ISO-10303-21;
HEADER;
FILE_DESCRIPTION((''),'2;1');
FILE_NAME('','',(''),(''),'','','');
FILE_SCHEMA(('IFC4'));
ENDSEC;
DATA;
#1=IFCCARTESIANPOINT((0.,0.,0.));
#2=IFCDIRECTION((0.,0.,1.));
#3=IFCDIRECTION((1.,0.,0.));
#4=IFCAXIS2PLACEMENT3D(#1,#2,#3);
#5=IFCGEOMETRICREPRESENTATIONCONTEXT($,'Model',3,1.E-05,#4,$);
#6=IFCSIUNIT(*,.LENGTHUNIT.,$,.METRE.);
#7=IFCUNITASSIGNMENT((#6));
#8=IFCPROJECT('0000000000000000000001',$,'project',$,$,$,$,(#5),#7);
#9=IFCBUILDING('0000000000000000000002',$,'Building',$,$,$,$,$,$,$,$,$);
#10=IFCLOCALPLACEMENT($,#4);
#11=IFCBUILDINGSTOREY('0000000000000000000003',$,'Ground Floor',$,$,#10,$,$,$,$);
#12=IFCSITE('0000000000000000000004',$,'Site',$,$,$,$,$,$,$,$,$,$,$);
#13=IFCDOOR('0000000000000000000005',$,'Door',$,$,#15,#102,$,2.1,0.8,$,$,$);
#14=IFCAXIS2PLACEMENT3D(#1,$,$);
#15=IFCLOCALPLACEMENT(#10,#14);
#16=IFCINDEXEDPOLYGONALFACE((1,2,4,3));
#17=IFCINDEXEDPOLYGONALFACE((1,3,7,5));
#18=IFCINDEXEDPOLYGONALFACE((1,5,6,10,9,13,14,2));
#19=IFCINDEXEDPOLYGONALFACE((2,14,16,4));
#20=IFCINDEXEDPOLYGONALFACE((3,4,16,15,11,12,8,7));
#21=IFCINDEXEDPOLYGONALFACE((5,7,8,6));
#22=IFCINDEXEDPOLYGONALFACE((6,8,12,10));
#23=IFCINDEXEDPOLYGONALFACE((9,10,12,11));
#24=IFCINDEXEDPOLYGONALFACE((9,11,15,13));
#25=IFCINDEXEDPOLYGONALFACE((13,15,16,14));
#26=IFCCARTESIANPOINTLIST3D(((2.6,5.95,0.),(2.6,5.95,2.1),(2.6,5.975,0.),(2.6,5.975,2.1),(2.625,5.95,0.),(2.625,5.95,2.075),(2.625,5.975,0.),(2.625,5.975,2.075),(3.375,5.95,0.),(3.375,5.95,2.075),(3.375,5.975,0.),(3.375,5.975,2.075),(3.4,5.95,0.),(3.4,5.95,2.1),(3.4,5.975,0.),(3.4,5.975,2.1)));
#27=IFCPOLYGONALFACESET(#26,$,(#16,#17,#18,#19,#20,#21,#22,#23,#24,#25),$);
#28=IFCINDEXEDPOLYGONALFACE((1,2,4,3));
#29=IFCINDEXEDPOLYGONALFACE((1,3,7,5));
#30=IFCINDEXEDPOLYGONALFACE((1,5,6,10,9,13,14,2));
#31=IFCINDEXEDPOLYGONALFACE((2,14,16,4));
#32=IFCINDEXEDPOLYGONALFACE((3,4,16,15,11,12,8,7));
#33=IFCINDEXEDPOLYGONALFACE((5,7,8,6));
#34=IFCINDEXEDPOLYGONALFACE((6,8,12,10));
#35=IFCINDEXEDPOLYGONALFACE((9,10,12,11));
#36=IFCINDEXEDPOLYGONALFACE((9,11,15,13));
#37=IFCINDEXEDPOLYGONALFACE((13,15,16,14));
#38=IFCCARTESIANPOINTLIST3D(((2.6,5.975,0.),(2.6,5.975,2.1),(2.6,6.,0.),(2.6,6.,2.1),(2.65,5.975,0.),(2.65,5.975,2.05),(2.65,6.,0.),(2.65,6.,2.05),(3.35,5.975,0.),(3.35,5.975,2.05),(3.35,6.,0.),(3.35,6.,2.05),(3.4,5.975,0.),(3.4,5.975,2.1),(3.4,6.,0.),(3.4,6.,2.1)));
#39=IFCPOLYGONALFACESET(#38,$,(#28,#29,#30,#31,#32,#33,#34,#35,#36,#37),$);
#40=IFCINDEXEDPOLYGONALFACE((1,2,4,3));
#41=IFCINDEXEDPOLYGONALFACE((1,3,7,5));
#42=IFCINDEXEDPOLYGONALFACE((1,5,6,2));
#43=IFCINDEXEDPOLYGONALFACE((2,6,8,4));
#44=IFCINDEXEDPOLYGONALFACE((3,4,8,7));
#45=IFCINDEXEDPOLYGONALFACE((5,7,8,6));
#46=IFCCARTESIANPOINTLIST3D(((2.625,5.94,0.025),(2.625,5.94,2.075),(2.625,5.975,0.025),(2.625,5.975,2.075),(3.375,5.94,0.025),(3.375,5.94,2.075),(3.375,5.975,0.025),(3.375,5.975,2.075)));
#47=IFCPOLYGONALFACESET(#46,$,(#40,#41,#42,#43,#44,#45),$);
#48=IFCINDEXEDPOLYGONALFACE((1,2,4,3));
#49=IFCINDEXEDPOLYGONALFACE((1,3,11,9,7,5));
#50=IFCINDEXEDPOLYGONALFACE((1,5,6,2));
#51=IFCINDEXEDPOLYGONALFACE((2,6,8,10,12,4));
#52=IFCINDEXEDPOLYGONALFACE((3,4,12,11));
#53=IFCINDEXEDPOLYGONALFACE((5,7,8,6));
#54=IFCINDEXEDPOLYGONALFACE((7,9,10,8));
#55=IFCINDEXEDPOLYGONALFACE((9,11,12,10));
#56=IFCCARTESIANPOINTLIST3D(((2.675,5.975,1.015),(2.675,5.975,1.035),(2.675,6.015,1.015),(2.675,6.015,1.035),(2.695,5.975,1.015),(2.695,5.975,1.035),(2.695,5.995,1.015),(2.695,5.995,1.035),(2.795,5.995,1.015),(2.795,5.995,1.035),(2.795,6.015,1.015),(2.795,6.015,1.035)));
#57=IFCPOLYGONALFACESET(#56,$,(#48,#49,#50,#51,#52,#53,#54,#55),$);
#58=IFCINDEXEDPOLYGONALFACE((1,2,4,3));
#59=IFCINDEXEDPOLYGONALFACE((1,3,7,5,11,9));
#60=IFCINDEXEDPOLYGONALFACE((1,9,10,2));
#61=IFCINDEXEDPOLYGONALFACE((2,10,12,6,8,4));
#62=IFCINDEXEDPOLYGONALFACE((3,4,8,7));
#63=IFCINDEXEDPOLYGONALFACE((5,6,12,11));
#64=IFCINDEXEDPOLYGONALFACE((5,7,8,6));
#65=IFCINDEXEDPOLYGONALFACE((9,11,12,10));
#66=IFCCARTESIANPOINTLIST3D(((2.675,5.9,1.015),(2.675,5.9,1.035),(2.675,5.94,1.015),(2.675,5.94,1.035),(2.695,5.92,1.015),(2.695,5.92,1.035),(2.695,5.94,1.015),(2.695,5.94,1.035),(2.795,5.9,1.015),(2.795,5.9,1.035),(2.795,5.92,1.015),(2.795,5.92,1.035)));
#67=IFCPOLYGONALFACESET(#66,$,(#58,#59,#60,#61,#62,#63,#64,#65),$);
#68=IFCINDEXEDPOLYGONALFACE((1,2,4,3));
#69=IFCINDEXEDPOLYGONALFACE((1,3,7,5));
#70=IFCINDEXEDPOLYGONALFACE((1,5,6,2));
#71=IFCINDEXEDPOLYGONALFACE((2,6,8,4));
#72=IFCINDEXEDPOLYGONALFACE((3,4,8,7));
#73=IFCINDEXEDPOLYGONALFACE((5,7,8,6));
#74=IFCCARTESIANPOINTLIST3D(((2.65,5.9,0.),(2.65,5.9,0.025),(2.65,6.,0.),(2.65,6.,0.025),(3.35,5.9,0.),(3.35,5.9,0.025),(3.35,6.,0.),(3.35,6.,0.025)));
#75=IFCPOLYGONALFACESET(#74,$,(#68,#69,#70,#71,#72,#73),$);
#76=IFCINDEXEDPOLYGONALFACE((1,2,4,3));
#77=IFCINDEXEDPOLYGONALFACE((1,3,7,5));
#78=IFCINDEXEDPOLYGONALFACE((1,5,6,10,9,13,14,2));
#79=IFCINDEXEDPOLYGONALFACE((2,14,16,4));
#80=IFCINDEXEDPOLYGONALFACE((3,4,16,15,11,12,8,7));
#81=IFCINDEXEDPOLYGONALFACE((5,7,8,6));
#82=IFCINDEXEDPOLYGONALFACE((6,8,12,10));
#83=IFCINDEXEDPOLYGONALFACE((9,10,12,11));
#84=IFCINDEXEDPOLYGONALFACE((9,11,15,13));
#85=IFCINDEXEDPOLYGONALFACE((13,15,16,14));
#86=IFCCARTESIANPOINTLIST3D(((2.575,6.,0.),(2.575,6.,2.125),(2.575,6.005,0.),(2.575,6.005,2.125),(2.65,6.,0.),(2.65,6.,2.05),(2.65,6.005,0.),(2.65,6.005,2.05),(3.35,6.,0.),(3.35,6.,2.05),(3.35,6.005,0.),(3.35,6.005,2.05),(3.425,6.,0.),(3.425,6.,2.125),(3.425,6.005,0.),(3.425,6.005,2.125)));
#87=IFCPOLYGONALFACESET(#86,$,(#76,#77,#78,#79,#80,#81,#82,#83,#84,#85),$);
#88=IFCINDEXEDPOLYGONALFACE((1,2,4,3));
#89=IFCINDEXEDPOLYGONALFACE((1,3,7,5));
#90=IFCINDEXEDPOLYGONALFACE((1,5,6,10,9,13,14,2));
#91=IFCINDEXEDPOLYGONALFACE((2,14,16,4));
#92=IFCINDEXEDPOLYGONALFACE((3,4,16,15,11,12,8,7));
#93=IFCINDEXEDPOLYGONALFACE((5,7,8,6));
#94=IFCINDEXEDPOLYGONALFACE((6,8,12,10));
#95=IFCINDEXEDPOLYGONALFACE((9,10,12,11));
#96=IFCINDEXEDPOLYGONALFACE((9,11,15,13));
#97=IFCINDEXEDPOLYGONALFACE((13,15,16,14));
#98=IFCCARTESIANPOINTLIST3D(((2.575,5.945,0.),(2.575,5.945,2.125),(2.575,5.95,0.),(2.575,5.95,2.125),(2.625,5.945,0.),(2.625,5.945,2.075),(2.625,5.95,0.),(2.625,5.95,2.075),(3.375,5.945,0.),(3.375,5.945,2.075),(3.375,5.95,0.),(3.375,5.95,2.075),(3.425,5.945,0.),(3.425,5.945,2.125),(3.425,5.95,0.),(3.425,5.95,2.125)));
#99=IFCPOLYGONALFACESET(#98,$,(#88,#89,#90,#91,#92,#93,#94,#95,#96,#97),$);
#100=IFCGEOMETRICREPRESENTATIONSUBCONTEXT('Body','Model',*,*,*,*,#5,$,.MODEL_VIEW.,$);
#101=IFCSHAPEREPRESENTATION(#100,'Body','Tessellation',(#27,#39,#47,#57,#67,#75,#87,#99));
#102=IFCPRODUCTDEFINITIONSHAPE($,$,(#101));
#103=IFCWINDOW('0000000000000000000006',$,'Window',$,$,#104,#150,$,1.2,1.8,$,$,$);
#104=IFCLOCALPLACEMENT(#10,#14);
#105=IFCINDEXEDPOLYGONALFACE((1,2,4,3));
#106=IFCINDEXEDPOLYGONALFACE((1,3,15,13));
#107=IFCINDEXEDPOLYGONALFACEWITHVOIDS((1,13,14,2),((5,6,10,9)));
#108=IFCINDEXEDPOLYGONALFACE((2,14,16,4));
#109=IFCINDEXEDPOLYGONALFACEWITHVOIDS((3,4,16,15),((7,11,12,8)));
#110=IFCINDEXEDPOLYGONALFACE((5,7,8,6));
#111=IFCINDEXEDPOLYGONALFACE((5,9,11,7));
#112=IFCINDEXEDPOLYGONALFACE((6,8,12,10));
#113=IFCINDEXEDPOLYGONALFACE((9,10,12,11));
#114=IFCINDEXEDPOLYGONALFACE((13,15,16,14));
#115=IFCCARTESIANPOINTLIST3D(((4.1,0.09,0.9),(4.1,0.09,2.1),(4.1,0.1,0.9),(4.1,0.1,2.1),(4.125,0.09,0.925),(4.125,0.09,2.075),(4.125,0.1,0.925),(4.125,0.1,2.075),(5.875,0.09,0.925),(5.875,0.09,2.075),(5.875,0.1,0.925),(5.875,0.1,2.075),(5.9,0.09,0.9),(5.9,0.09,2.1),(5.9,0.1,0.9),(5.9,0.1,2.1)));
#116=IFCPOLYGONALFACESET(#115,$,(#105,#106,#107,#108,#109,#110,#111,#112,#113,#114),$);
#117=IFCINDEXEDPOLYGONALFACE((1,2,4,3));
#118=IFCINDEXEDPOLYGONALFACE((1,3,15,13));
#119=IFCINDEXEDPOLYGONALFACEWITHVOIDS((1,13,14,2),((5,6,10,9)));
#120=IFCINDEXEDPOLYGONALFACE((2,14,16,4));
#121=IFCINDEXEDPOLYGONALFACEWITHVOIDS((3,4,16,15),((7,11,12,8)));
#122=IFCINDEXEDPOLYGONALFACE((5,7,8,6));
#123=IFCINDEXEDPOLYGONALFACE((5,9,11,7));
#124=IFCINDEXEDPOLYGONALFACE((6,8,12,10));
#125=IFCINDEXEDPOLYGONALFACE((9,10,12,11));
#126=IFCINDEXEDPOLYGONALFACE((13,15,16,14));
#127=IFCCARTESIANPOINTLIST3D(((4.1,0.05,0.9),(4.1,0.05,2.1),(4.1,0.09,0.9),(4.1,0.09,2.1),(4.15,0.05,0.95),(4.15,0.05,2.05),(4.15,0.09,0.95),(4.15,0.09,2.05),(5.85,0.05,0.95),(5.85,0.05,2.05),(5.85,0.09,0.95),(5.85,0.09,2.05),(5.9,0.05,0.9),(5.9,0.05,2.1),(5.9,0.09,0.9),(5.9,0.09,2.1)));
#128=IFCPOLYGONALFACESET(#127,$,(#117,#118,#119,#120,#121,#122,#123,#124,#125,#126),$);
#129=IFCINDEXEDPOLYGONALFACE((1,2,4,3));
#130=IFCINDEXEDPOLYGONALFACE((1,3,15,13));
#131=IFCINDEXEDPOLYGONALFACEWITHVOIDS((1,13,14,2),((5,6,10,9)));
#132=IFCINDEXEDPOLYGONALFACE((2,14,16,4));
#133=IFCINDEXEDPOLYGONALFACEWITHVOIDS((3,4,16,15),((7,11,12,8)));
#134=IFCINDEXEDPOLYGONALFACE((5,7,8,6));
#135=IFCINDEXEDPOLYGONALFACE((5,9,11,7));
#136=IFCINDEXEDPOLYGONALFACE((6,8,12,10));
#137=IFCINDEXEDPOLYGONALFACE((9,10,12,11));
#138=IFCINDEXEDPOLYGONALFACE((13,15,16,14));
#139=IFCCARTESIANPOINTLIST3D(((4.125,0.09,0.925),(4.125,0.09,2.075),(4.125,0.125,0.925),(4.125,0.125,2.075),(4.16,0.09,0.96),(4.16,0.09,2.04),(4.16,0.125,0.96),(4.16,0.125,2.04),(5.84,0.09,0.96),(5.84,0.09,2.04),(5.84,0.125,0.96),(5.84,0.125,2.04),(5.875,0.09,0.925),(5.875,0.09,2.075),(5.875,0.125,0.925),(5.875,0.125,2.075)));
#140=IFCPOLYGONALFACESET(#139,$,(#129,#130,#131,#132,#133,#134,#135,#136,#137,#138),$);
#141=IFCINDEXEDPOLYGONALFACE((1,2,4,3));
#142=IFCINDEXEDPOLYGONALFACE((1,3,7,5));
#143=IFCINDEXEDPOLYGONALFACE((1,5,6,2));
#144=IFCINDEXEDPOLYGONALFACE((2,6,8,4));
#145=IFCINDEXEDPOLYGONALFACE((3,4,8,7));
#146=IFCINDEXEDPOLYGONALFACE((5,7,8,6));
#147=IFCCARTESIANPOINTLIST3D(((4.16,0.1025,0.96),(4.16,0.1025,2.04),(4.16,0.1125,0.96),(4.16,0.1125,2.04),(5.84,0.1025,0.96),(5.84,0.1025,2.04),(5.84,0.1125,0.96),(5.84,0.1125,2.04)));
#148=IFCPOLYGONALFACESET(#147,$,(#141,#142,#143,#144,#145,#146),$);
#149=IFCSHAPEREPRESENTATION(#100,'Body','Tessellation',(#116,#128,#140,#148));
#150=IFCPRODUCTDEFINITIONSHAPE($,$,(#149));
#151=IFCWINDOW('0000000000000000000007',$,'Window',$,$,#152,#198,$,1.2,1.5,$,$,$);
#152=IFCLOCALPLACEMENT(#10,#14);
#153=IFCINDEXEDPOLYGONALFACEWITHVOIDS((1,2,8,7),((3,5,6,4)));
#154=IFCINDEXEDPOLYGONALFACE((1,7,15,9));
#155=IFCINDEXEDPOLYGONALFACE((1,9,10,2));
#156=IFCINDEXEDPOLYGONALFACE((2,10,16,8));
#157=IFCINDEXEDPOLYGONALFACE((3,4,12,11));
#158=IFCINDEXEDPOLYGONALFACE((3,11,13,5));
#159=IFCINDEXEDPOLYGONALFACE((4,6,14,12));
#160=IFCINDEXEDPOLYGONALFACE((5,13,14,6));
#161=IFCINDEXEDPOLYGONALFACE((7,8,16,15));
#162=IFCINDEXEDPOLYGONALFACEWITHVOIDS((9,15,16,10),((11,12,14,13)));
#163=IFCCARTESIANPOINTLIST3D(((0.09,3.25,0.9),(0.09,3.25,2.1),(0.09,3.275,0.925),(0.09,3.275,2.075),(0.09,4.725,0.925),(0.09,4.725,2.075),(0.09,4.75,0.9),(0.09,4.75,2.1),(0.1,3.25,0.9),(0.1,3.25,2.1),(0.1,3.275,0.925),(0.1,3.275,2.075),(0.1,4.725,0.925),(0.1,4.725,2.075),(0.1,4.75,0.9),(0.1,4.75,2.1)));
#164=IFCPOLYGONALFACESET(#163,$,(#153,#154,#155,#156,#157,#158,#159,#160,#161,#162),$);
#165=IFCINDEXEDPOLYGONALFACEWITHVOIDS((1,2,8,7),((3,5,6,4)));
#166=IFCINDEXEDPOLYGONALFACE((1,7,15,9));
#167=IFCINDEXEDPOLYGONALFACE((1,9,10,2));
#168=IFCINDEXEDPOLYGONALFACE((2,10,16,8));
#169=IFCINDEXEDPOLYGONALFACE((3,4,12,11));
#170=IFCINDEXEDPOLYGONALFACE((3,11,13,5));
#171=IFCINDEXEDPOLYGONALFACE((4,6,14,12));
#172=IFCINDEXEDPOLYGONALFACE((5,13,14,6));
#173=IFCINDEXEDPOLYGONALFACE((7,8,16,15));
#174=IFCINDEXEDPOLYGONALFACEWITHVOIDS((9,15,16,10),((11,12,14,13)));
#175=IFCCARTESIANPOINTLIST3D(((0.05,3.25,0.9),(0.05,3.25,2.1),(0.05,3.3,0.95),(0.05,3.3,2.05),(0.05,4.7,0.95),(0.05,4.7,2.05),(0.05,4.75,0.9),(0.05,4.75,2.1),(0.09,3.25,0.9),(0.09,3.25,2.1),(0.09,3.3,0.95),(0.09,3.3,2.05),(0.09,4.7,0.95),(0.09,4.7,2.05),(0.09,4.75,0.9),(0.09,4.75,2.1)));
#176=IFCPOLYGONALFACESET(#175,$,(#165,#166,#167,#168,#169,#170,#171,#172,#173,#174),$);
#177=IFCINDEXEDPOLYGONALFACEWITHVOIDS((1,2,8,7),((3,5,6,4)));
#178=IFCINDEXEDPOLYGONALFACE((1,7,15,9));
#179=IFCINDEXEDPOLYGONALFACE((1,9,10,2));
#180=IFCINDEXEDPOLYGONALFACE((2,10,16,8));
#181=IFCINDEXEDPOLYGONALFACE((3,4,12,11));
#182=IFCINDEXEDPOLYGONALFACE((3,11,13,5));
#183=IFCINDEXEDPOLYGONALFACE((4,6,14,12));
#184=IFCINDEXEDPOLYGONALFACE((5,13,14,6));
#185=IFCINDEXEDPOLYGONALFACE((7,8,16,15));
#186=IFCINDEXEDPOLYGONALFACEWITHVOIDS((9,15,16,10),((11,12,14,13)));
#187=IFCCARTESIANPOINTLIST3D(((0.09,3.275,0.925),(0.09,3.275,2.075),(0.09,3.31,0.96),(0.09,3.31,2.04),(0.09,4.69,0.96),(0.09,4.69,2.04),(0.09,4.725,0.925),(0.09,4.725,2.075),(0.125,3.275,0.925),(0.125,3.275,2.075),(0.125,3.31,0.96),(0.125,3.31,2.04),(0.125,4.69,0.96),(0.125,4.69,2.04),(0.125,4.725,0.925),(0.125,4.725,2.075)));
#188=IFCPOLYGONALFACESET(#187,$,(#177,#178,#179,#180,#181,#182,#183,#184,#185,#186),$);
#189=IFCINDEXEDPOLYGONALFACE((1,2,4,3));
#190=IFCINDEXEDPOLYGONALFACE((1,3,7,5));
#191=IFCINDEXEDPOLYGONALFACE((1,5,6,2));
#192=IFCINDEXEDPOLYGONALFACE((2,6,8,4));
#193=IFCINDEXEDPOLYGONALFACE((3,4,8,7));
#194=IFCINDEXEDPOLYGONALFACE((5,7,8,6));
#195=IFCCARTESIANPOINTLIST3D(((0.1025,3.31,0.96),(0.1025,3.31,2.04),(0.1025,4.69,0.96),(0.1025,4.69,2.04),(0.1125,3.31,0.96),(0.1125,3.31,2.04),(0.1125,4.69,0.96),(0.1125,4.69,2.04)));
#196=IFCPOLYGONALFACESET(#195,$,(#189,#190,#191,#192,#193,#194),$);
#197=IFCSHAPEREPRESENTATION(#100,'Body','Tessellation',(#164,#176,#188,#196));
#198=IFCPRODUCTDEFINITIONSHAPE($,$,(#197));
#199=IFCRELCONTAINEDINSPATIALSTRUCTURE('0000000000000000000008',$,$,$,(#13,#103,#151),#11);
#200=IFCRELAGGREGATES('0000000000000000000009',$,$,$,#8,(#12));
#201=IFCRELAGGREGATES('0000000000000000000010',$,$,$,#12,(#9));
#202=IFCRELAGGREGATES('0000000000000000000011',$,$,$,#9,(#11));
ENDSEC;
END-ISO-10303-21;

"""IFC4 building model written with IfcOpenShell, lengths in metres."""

from ifc_helpers import new_model, si_unit, frame, origin_with_axes, place, context, subcontext, project, spatial, line, indexed_curve, outline, extrude, element, save


model = new_model("IFC4")

# Units and contexts
model_context = context("Model", 3, precision=1e-05, world=origin_with_axes())
body_context = subcontext(model_context, "Body", "Model", "MODEL_VIEW")
ifc_project = project(units=[si_unit("LENGTHUNIT", "METRE")], contexts=[model_context])

# Site, building, storey
site = spatial("IfcSite", under=ifc_project, Name="Site")
building = spatial("IfcBuilding", under=site, Name="Building")
storey_placement = place(None, origin_with_axes())
storey = spatial("IfcBuildingStorey", under=building, at=storey_placement, Name="Ground Floor")

# Door
door_1_placement = place(storey_placement, frame((3.4, 6.0, 0.0), z_axis=(0.0, 0.0, 1.0), x_axis=(-1.0, 0.0, 0.0)))
element("IfcDoor", 1, at=door_1_placement, inside=storey, Name="Door", OverallHeight=2.1, OverallWidth=0.8, context=body_context, shape_type="SweptSolid", body=[
    extrude(outline(indexed_curve([(0.0, 0.0), (0.0, 2.1), (0.8, 2.1), (0.8, 0.0), (0.775, 0.0), (0.775, 2.075), (0.025, 2.075), (0.025, 0.0)], segments=[line(1, 2, 3, 4, 5, 6, 7, 8, 1)])), frame((0.0, 0.025, 0.0), z_axis=(0.0, -1.0, 0.0), x_axis=(1.0, 0.0, 0.0)), (0.0, 0.0, -1.0), 0.025),
    extrude(outline(indexed_curve([(0.0, 0.0), (0.0, 2.1), (0.8, 2.1), (0.8, 0.0), (0.75, 0.0), (0.75, 2.05), (0.05, 2.05), (0.05, 0.0)], segments=[line(1, 2, 3, 4, 5, 6, 7, 8, 1)])), frame((0.0, 0.0, 0.0), z_axis=(0.0, -1.0, 0.0), x_axis=(1.0, 0.0, 0.0)), (0.0, 0.0, -1.0), 0.025),
    extrude(outline(indexed_curve([(0.0, 0.0), (0.75, 0.0), (0.75, 0.035), (0.0, 0.035)], segments=[line(1, 2, 3, 4, 1)])), frame((0.025, 0.025, 0.025), z_axis=(0.0, 0.0, 1.0), x_axis=(1.0, 0.0, 0.0)), (0.0, 0.0, 1.0), 2.05),
    extrude(outline(indexed_curve([(0.0, 0.0), (0.0, -0.04), (-0.12, -0.04), (-0.12, -0.02), (-0.02, -0.02), (-0.02, 0.0)], segments=[line(1, 2, 3, 4, 5, 6, 1)])), frame((0.725, 0.025, 1.015), z_axis=(0.0, 0.0, 1.0), x_axis=(1.0, 0.0, 0.0)), (0.0, 0.0, 1.0), 0.02),
    extrude(outline(indexed_curve([(0.0, 0.0), (0.0, 0.04), (-0.12, 0.04), (-0.12, 0.02), (-0.02, 0.02), (-0.02, 0.0)], segments=[line(1, 2, 3, 4, 5, 6, 1)])), frame((0.725, 0.06, 1.015), z_axis=(0.0, 0.0, 1.0), x_axis=(1.0, 0.0, 0.0)), (0.0, 0.0, 1.0), 0.02),
    extrude(outline(indexed_curve([(0.0, 0.0), (0.7, 0.0), (0.7, 0.1), (0.0, 0.1)], segments=[line(1, 2, 3, 4, 1)])), frame((0.05, 0.0, 0.0), z_axis=(0.0, 0.0, 1.0), x_axis=(1.0, 0.0, 0.0)), (0.0, 0.0, 1.0), 0.025),
    extrude(outline(indexed_curve([(0.0, 0.0), (0.0, 2.125), (0.85, 2.125), (0.85, 0.0), (0.775, 0.0), (0.775, 2.05), (0.075, 2.05), (0.075, 0.0)], segments=[line(1, 2, 3, 4, 5, 6, 7, 8, 1)])), frame((-0.025, -0.005, 0.0), z_axis=(0.0, -1.0, 0.0), x_axis=(1.0, 0.0, 0.0)), (0.0, 0.0, -1.0), 0.005),
    extrude(outline(indexed_curve([(0.0, 0.0), (0.0, 2.125), (0.85, 2.125), (0.85, 0.0), (0.8, 0.0), (0.8, 2.075), (0.05, 2.075), (0.05, 0.0)], segments=[line(1, 2, 3, 4, 5, 6, 7, 8, 1)])), frame((-0.025, 0.05, 0.0), z_axis=(0.0, -1.0, 0.0), x_axis=(1.0, 0.0, 0.0)), (0.0, 0.0, -1.0), 0.005),
])

# Windows
window_placement = place(storey_placement, frame((4.1, 0.0, 0.9), z_axis=(0.0, 0.0, 1.0), x_axis=(1.0, 0.0, 0.0)))
element("IfcWindow", 2, at=window_placement, inside=storey, Name="Window", OverallHeight=1.2, OverallWidth=1.8, context=body_context, shape_type="SweptSolid", body=[
    extrude(outline(indexed_curve([(0.0, 0.0), (1.8, 0.0), (1.8, 1.2), (0.0, 1.2)], segments=[line(1, 2, 3, 4, 1)]), holes=[indexed_curve([(0.025, 0.025), (1.775, 0.025), (1.775, 1.175), (0.025, 1.175)], segments=[line(1, 2, 3, 4, 1)])]), frame((0.0, 0.09, 0.0), z_axis=(0.0, -1.0, 0.0), x_axis=(1.0, 0.0, 0.0)), (0.0, 0.0, -1.0), 0.01),
    extrude(outline(indexed_curve([(0.0, 0.0), (1.8, 0.0), (1.8, 1.2), (0.0, 1.2)], segments=[line(1, 2, 3, 4, 1)]), holes=[indexed_curve([(0.05, 0.05), (1.75, 0.05), (1.75, 1.15), (0.05, 1.15)], segments=[line(1, 2, 3, 4, 1)])]), frame((0.0, 0.05, 0.0), z_axis=(0.0, -1.0, 0.0), x_axis=(1.0, 0.0, 0.0)), (0.0, 0.0, -1.0), 0.04),
    extrude(outline(indexed_curve([(0.0, 0.0), (1.75, 0.0), (1.75, 1.15), (0.0, 1.15)], segments=[line(1, 2, 3, 4, 1)]), holes=[indexed_curve([(0.035, 0.035), (1.715, 0.035), (1.715, 1.115), (0.035, 1.115)], segments=[line(1, 2, 3, 4, 1)])]), frame((0.025, 0.09, 0.025), z_axis=(0.0, -1.0, 0.0), x_axis=(1.0, 0.0, 0.0)), (0.0, 0.0, -1.0), 0.035),
    extrude(outline(indexed_curve([(0.035, 0.035), (1.715, 0.035), (1.715, 1.115), (0.035, 1.115)], segments=[line(1, 2, 3, 4, 1)])), frame((0.025, 0.1025, 0.025), z_axis=(0.0, -1.0, 0.0), x_axis=(1.0, 0.0, 0.0)), (0.0, 0.0, -1.0), 0.01),
])
for number, where, z_axis, x_axis, name in (
    (3, (0.0, 4.75, 0.9), (0.0, 0.0, 1.0), (0.0, -1.0, 0.0), "Window"),
):
    element("IfcWindow", number, at=place(storey_placement, frame(where, z_axis=z_axis, x_axis=x_axis)), inside=storey, Name=name, OverallHeight=1.2, OverallWidth=1.5, context=body_context, shape_type="SweptSolid", body=[
        extrude(outline(indexed_curve([(0.0, 0.0), (1.5, 0.0), (1.5, 1.2), (0.0, 1.2)], segments=[line(1, 2, 3, 4, 1)]), holes=[indexed_curve([(0.025, 0.025), (1.475, 0.025), (1.475, 1.175), (0.025, 1.175)], segments=[line(1, 2, 3, 4, 1)])]), frame((0.0, 0.09, 0.0), z_axis=(0.0, -1.0, 0.0), x_axis=(1.0, 0.0, 0.0)), (0.0, 0.0, -1.0), 0.01),
        extrude(outline(indexed_curve([(0.0, 0.0), (1.5, 0.0), (1.5, 1.2), (0.0, 1.2)], segments=[line(1, 2, 3, 4, 1)]), holes=[indexed_curve([(0.05, 0.05), (1.45, 0.05), (1.45, 1.15), (0.05, 1.15)], segments=[line(1, 2, 3, 4, 1)])]), frame((0.0, 0.05, 0.0), z_axis=(0.0, -1.0, 0.0), x_axis=(1.0, 0.0, 0.0)), (0.0, 0.0, -1.0), 0.04),
        extrude(outline(indexed_curve([(0.0, 0.0), (1.45, 0.0), (1.45, 1.15), (0.0, 1.15)], segments=[line(1, 2, 3, 4, 1)]), holes=[indexed_curve([(0.035, 0.035), (1.415, 0.035), (1.415, 1.115), (0.035, 1.115)], segments=[line(1, 2, 3, 4, 1)])]), frame((0.025, 0.09, 0.025), z_axis=(0.0, -1.0, 0.0), x_axis=(1.0, 0.0, 0.0)), (0.0, 0.0, -1.0), 0.035),
        extrude(outline(indexed_curve([(0.035, 0.035), (1.415, 0.035), (1.415, 1.115), (0.035, 1.115)], segments=[line(1, 2, 3, 4, 1)])), frame((0.025, 0.1025, 0.025), z_axis=(0.0, -1.0, 0.0), x_axis=(1.0, 0.0, 0.0)), (0.0, 0.0, -1.0), 0.01),
    ])

save(model, "model.ifc")
